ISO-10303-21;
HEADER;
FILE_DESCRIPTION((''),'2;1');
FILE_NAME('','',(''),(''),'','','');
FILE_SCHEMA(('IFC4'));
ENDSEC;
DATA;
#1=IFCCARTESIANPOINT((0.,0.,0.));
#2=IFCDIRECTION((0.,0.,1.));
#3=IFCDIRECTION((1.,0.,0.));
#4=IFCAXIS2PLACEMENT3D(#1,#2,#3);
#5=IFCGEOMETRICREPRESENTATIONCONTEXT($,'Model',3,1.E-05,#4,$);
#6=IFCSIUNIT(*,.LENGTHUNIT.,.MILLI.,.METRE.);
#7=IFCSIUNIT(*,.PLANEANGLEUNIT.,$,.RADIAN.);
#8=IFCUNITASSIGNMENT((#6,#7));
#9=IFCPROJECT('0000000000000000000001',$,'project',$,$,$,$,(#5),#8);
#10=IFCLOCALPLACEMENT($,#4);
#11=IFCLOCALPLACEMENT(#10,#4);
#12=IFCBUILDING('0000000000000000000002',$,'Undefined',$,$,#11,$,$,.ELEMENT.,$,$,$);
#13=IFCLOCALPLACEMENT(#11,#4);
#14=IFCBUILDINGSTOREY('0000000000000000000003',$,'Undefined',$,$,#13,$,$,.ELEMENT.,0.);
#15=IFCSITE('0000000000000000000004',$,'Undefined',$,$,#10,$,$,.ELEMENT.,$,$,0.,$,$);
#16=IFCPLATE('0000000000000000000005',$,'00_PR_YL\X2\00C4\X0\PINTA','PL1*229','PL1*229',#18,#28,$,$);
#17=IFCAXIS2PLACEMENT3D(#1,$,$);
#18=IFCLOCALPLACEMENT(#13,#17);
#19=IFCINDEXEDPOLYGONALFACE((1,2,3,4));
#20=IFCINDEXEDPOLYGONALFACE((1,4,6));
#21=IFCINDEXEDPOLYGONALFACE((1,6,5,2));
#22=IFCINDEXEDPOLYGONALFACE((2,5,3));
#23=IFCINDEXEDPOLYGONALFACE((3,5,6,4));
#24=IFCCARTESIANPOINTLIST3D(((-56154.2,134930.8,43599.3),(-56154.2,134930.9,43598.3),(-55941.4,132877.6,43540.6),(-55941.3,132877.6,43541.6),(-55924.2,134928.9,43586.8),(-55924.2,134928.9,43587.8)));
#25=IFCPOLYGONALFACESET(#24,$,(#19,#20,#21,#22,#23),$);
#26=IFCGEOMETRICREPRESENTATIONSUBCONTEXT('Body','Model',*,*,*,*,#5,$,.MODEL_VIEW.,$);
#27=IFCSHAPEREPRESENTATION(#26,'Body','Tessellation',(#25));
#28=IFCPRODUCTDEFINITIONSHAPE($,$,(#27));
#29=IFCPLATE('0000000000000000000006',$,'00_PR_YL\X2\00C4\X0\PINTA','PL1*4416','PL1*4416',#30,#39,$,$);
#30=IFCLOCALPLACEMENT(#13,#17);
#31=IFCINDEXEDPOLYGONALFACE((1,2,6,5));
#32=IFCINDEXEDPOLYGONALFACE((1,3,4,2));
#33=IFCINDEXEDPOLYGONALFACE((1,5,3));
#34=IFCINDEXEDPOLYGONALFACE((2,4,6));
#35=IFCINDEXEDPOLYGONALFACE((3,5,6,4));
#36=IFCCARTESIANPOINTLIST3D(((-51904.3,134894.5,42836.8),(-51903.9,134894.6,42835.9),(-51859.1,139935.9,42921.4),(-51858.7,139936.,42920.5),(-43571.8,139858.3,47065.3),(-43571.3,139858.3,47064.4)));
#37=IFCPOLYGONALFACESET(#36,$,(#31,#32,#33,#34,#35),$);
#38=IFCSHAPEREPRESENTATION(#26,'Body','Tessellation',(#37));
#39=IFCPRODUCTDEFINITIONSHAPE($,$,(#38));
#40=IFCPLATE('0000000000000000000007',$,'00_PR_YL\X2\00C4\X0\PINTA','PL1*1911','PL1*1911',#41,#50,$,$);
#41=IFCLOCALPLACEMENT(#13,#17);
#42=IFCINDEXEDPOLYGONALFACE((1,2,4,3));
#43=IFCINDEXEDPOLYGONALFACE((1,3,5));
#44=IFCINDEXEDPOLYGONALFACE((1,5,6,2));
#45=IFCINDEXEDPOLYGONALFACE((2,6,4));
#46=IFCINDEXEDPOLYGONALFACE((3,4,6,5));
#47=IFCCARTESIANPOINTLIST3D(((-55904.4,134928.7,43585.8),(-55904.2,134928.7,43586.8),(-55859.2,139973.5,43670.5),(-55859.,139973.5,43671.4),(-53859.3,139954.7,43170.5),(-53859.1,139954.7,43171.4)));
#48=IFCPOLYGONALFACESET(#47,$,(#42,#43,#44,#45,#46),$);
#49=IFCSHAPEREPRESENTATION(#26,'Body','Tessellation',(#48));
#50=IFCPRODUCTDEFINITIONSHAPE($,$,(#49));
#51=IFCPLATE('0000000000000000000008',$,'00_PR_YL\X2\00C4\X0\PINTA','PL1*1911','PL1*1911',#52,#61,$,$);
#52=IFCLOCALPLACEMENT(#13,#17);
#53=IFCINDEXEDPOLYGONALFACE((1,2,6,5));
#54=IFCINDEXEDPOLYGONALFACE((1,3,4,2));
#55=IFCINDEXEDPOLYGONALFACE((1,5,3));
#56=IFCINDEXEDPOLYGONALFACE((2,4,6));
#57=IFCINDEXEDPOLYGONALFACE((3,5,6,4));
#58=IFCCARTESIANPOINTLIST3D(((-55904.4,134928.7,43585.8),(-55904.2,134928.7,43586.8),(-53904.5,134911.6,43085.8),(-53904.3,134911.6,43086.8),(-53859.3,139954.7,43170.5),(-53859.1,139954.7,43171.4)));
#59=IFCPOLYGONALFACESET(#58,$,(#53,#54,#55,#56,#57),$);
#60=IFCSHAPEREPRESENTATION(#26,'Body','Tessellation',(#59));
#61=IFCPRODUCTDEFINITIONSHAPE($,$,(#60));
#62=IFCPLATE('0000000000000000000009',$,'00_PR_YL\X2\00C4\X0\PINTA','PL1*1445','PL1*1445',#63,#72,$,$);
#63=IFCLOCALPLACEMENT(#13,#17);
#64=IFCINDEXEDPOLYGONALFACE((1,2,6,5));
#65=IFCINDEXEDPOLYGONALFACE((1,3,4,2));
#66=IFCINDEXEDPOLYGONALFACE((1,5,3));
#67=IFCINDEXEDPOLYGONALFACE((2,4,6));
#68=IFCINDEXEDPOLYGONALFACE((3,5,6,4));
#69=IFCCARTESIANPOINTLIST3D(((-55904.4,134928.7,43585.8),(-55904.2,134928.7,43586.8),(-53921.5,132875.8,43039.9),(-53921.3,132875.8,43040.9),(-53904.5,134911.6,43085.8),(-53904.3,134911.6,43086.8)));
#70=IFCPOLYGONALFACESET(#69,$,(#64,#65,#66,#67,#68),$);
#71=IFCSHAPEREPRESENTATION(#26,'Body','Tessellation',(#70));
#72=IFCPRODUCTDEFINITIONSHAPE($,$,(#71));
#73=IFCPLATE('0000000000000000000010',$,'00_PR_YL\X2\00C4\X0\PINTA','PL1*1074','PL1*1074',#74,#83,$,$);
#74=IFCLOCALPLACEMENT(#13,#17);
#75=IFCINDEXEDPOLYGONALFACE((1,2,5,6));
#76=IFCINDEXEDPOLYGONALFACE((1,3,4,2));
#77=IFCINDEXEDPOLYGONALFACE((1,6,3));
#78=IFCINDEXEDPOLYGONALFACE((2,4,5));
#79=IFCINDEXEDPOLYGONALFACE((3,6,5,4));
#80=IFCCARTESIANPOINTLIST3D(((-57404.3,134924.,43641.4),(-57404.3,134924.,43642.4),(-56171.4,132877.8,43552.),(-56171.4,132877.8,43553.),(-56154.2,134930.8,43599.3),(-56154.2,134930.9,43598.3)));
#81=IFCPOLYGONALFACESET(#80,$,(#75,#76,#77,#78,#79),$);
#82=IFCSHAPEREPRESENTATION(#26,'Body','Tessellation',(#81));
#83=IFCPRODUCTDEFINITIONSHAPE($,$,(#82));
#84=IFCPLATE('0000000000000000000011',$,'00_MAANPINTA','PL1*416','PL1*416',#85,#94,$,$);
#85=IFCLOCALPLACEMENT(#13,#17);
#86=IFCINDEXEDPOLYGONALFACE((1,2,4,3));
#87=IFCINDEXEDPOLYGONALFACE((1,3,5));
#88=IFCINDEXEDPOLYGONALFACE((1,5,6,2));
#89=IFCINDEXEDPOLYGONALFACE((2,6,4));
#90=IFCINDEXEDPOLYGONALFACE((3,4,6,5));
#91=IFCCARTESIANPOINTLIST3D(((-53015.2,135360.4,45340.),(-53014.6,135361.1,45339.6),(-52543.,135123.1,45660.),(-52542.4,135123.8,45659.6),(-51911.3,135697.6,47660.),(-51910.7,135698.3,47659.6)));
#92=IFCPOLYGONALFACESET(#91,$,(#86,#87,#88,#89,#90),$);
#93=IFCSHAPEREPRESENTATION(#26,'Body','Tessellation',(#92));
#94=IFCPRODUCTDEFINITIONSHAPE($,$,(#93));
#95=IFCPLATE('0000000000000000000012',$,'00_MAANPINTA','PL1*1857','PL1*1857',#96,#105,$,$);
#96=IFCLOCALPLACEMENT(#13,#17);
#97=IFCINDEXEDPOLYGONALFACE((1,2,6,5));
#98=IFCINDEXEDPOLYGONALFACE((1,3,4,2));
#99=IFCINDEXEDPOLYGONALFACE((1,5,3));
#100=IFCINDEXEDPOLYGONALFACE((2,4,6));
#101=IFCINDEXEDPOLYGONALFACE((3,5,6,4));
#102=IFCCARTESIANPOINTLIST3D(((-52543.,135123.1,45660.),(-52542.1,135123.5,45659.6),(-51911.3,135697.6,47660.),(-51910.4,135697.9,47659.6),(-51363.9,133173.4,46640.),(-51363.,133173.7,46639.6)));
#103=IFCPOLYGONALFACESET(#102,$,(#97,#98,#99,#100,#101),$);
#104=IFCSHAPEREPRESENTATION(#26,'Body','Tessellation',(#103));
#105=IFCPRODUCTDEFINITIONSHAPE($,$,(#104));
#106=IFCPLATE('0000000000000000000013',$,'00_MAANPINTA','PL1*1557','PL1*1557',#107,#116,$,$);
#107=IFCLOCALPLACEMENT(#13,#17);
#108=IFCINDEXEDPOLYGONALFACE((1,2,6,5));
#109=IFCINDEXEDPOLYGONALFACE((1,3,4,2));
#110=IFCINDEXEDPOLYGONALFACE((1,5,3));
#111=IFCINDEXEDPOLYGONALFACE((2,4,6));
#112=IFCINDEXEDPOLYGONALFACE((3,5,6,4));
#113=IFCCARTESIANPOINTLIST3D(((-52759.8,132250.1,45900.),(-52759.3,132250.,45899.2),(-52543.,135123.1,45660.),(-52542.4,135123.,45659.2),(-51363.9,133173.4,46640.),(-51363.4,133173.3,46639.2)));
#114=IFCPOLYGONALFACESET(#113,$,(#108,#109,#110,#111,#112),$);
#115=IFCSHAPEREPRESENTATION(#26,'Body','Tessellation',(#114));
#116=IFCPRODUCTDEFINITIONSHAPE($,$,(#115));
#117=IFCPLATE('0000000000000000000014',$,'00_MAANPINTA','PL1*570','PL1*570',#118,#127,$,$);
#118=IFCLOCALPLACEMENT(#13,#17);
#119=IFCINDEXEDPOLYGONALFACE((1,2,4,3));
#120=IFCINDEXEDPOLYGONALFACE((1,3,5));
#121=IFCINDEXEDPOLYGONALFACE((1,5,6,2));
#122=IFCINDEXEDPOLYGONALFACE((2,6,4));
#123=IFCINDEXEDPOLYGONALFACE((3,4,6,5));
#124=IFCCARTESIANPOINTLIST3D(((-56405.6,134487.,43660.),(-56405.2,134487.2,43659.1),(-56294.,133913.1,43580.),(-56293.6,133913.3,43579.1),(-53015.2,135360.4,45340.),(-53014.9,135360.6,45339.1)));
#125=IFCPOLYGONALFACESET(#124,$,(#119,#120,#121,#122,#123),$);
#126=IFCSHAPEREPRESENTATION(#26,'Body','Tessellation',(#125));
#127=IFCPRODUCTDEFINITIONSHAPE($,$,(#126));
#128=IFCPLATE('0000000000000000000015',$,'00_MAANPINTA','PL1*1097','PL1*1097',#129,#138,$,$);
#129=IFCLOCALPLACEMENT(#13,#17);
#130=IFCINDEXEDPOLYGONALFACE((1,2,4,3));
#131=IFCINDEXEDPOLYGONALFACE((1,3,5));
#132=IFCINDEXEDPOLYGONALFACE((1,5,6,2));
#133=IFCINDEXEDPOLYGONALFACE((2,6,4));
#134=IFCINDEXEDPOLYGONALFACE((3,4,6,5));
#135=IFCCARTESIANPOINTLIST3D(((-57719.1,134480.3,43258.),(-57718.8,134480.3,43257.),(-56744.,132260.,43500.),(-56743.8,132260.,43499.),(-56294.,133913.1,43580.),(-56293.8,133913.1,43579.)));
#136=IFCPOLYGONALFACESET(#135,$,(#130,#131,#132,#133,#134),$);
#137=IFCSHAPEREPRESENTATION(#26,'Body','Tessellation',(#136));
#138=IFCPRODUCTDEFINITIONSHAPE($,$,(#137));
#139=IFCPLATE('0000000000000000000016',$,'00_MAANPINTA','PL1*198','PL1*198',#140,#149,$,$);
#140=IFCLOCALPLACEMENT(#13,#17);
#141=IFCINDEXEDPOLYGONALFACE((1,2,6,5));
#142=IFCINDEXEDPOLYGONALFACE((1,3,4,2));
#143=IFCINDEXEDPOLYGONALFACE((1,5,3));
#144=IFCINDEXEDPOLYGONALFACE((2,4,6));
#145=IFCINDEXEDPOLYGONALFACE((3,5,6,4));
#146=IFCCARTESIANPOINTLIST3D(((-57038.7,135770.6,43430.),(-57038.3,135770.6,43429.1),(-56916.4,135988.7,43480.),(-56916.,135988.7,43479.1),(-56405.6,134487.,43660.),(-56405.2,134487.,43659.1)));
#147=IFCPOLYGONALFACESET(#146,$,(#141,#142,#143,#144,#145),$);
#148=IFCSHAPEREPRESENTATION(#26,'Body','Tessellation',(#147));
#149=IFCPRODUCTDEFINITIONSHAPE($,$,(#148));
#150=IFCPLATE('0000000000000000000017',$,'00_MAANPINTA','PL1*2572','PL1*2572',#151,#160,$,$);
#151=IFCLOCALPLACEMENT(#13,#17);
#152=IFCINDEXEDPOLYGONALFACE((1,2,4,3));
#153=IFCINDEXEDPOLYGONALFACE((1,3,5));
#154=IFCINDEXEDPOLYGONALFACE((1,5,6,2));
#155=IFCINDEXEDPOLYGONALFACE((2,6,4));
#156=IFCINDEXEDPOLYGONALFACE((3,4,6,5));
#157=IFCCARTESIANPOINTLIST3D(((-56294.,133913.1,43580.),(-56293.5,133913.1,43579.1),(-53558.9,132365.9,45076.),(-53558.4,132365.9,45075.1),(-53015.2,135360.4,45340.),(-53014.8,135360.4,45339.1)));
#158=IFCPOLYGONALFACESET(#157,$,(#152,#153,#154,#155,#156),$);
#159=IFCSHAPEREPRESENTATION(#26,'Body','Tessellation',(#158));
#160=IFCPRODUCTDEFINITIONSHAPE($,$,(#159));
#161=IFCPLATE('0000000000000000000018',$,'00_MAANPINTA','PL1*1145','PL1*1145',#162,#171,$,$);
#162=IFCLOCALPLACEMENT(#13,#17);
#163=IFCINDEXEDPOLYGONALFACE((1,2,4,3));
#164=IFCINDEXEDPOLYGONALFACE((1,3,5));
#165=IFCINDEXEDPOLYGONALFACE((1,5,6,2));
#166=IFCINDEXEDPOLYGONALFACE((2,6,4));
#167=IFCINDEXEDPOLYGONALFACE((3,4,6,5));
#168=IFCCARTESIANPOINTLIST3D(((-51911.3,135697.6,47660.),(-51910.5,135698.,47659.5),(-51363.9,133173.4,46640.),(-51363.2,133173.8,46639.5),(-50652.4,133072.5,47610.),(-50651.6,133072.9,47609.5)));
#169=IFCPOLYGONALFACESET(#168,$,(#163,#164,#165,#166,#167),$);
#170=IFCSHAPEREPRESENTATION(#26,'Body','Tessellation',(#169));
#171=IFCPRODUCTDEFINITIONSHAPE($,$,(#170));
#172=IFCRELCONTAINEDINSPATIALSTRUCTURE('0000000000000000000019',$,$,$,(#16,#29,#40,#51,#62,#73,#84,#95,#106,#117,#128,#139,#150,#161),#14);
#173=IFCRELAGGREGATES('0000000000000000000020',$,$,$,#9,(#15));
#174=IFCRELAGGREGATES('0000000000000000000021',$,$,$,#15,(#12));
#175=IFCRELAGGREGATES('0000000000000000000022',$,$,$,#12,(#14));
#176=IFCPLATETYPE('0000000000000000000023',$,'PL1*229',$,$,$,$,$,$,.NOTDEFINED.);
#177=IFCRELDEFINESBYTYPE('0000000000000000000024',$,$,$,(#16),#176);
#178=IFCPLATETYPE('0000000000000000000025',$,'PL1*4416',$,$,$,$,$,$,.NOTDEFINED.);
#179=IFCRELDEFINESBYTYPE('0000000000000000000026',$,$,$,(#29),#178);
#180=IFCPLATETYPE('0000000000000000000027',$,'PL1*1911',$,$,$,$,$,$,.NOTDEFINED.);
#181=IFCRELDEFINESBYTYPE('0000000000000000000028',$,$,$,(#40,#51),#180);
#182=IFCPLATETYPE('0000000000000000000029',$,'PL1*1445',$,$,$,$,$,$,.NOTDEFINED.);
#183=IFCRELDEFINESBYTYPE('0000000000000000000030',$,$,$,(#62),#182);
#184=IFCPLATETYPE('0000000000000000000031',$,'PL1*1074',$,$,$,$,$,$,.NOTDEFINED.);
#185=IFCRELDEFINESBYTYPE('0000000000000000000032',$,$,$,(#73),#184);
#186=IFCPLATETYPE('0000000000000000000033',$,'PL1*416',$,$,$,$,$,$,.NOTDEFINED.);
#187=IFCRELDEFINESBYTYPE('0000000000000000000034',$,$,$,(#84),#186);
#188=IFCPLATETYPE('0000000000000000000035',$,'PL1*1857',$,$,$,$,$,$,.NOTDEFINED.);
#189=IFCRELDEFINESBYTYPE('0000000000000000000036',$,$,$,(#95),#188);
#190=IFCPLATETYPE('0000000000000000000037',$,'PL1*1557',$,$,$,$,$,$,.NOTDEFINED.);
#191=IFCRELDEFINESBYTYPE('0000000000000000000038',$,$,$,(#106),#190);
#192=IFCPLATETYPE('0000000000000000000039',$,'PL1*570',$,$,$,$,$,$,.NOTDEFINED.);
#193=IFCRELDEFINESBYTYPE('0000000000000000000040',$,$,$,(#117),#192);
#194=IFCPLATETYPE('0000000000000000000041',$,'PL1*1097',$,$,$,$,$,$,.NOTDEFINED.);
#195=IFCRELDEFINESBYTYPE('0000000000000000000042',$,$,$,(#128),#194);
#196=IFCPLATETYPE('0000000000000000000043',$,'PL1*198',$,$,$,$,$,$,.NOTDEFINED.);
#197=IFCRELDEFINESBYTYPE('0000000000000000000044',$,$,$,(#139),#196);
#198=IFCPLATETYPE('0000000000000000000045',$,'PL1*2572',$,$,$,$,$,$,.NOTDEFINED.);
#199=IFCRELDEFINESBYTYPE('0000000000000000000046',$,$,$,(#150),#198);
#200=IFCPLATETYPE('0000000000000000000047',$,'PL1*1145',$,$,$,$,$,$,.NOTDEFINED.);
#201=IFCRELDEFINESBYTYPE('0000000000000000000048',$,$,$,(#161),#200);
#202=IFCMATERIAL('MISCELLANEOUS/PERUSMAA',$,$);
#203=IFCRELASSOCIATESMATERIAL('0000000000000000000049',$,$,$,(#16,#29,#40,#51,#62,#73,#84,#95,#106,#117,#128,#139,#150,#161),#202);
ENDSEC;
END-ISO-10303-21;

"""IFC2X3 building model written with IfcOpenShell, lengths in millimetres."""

from ifc_helpers import new_model, si_unit, frame, origin_with_axes, place, context, subcontext, project, spatial, polyline, outline, extrude, material, type_object, element, save


model = new_model("IFC2X3")

# Units and contexts
model_context = context("Model", 3, precision=1e-05, world=origin_with_axes())
body_context = subcontext(model_context, "Body", "Model", "MODEL_VIEW")
ifc_project = project(units=[si_unit("LENGTHUNIT", "METRE", prefix="MILLI"), si_unit("PLANEANGLEUNIT", "RADIAN")], contexts=[model_context])

# Site, building, storey
site_placement = place(None, origin_with_axes())
site = spatial("IfcSite", under=ifc_project, at=site_placement, Name="Undefined", CompositionType="ELEMENT", RefElevation=0.0)
building_placement = place(site_placement, origin_with_axes())
building = spatial("IfcBuilding", under=site, at=building_placement, Name="Undefined", CompositionType="ELEMENT")
storey_placement = place(building_placement, origin_with_axes())
storey = spatial("IfcBuildingStorey", under=building, at=storey_placement, Name="Undefined", CompositionType="ELEMENT", Elevation=0.0)

# Plates
ifc_material = material(Name="MISCELLANEOUS/PERUSMAA")
plate_type_1 = type_object("IfcPlateType", Name="PL1*229", PredefinedType="NOTDEFINED")
plate_1_placement = place(storey_placement, frame((-55924.2, 134928.9, 43587.3), z_axis=(-0.049732, 0.022903, -0.9985), x_axis=(-0.008366, -0.999712, -0.022514)))
element("IfcPlate", 1, at=plate_1_placement, inside=storey, type_object=plate_type_1, material=ifc_material, Name="00_PR_YLÄPINTA", Description="PL1*229", ObjectType="PL1*229", context=body_context, shape_type="SweptSolid", body=[
    extrude(outline(polyline([(0.0, 0.0), (2051.9, 0.0), (-0.3, 230.3), (0.0, 0.0)])), frame((0.0, 0.0, -0.5), z_axis=(0.0, 0.0, 1.0), x_axis=(1.0, 0.0, 0.0)), (0.0, 0.0, 1.0), 1.0),
])
plate_type_2 = type_object("IfcPlateType", Name="PL1*4416", PredefinedType="NOTDEFINED")
plate_2_placement = place(storey_placement, frame((-51904.1, 134894.6, 42836.3), z_axis=(0.447285, 0.011013, -0.894324), x_axis=(0.00896, 0.999819, 0.016793)))
element("IfcPlate", 2, at=plate_2_placement, inside=storey, type_object=plate_type_2, material=ifc_material, Name="00_PR_YLÄPINTA", Description="PL1*4416", ObjectType="PL1*4416", context=body_context, shape_type="SweptSolid", body=[
    extrude(outline(polyline([(0.0, 0.0), (5042.3, 0.0), (5108.5, 9265.8), (0.0, 0.0)])), frame((0.0, 0.0, -0.5), z_axis=(0.0, 0.0, 1.0), x_axis=(1.0, 0.0, 0.0)), (0.0, 0.0, 1.0), 1.0),
])
plate_type_3 = type_object("IfcPlateType", Name="PL1*1911", PredefinedType="NOTDEFINED")
plate_3_placement = place(storey_placement, frame((-53859.2, 139954.7, 43171.0), z_axis=(-0.242341, 0.018453, -0.970016), x_axis=(-0.3758, -0.923553, 0.076318)))
element("IfcPlate", 3, at=plate_3_placement, inside=storey, type_object=plate_type_3, material=ifc_material, Name="00_PR_YLÄPINTA", Description="PL1*1911", ObjectType="PL1*1911", context=body_context, shape_type="SweptSolid", body=[
    extrude(outline(polyline([(0.0, 0.0), (5442.0, 0.0), (772.4, 1911.4), (0.0, 0.0)])), frame((0.0, 0.0, -0.5), z_axis=(0.0, 0.0, 1.0), x_axis=(1.0, 0.0, 0.0)), (0.0, 0.0, 1.0), 1.0),
])
plate_4_placement = place(storey_placement, frame((-53859.2, 139954.7, 43171.0), z_axis=(-0.242354, 0.018459, -0.970012), x_axis=(-0.00896, -0.999819, -0.016788)))
element("IfcPlate", 4, at=plate_4_placement, inside=storey, type_object=plate_type_3, material=ifc_material, Name="00_PR_YLÄPINTA", Description="PL1*1911", ObjectType="PL1*1911", context=body_context, shape_type="SweptSolid", body=[
    extrude(outline(polyline([(0.0, 0.0), (5044.0, 0.0), (5036.4, 2061.5), (0.0, 0.0)])), frame((0.0, 0.0, -0.5), z_axis=(0.0, 0.0, 1.0), x_axis=(1.0, 0.0, 0.0)), (0.0, 0.0, 1.0), 1.0),
])
plate_type_4 = type_object("IfcPlateType", Name="PL1*1445", PredefinedType="NOTDEFINED")
plate_5_placement = place(storey_placement, frame((-55904.3, 134928.7, 43586.3), z_axis=(-0.242283, 0.023878, -0.969912), x_axis=(0.970107, -0.008284, -0.242536)))
element("IfcPlate", 5, at=plate_5_placement, inside=storey, type_object=plate_type_4, material=ifc_material, Name="00_PR_YLÄPINTA", Description="PL1*1445", ObjectType="PL1*1445", context=body_context, shape_type="SweptSolid", body=[
    extrude(outline(polyline([(0.0, 0.0), (2061.6, 0.0), (2073.0, 2036.4), (0.0, 0.0)])), frame((0.0, 0.0, -0.5), z_axis=(0.0, 0.0, 1.0), x_axis=(1.0, 0.0, 0.0)), (0.0, 0.0, 1.0), 1.0),
])
plate_type_5 = type_object("IfcPlateType", Name="PL1*1074", PredefinedType="NOTDEFINED")
plate_6_placement = place(storey_placement, frame((-56154.2, 134930.8, 43598.8), z_axis=(-0.03464, 0.022791, -0.99914), x_axis=(-0.008365, -0.999712, -0.022514)))
element("IfcPlate", 6, at=plate_6_placement, inside=storey, type_object=plate_type_5, material=ifc_material, Name="00_PR_YLÄPINTA", Description="PL1*1074", ObjectType="PL1*1074", context=body_context, shape_type="SweptSolid", body=[
    extrude(outline(polyline([(0.0, 0.0), (2053.6, 0.0), (16.3, 1250.8), (0.0, 0.0)])), frame((0.0, 0.0, -0.5), z_axis=(0.0, 0.0, 1.0), x_axis=(1.0, 0.0, 0.0)), (0.0, 0.0, 1.0), 1.0),
])
plate_type_6 = type_object("IfcPlateType", Name="PL1*416", PredefinedType="NOTDEFINED")
plate_7_placement = place(storey_placement, frame((-51911.0, 135697.9, 47659.8), z_axis=(0.610773, 0.688694, -0.390714), x_axis=(-0.290468, -0.264166, -0.919698)))
element("IfcPlate", 7, at=plate_7_placement, inside=storey, type_object=plate_type_6, material=ifc_material, Name="00_MAANPINTA", Description="PL1*416", ObjectType="PL1*416", context=body_context, shape_type="SweptSolid", body=[
    extrude(outline(polyline([(0.0, 0.0), (2174.6, 0.0), (2543.4, 495.7), (0.0, 0.0)])), frame((0.0, 0.0, -0.5), z_axis=(0.0, 0.0, 1.0), x_axis=(1.0, 0.0, 0.0)), (0.0, 0.0, 1.0), 1.0),
])
plate_type_7 = type_object("IfcPlateType", Name="PL1*1857", PredefinedType="NOTDEFINED")
plate_8_placement = place(storey_placement, frame((-51363.5, 133173.6, 46639.8), z_axis=(0.86553, 0.337307, -0.370245), x_axis=(-0.475359, 0.786082, -0.395107)))
element("IfcPlate", 8, at=plate_8_placement, inside=storey, type_object=plate_type_7, material=ifc_material, Name="00_MAANPINTA", Description="PL1*1857", ObjectType="PL1*1857", context=body_context, shape_type="SweptSolid", body=[
    extrude(outline(polyline([(0.0, 0.0), (2480.3, 0.0), (1841.4, 2078.7), (0.0, 0.0)])), frame((0.0, 0.0, -0.5), z_axis=(0.0, 0.0, 1.0), x_axis=(1.0, 0.0, 0.0)), (0.0, 0.0, 1.0), 1.0),
])
plate_type_8 = type_object("IfcPlateType", Name="PL1*1557", PredefinedType="NOTDEFINED")
plate_9_placement = place(storey_placement, frame((-52542.7, 135123.1, 45659.6), z_axis=(0.521377, -0.110038, -0.846202), x_axis=(0.475359, -0.786082, 0.395107)))
element("IfcPlate", 9, at=plate_9_placement, inside=storey, type_object=plate_type_8, material=ifc_material, Name="00_MAANPINTA", Description="PL1*1557", ObjectType="PL1*1557", context=body_context, shape_type="SweptSolid", body=[
    extrude(outline(polyline([(0.0, 0.0), (2480.3, 0.0), (2250.2, 1815.4), (0.0, 0.0)])), frame((0.0, 0.0, -0.5), z_axis=(0.0, 0.0, 1.0), x_axis=(1.0, 0.0, 0.0)), (0.0, 0.0, 1.0), 1.0),
])
plate_type_9 = type_object("IfcPlateType", Name="PL1*570", PredefinedType="NOTDEFINED")
plate_10_placement = place(storey_placement, frame((-56293.8, 133913.2, 43579.6), z_axis=(0.392745, 0.201443, -0.897314), x_axis=(-0.189086, 0.972556, 0.135574)))
element("IfcPlate", 10, at=plate_10_placement, inside=storey, type_object=plate_type_9, material=ifc_material, Name="00_MAANPINTA", Description="PL1*570", ObjectType="PL1*570", context=body_context, shape_type="SweptSolid", body=[
    extrude(outline(polyline([(0.0, 0.0), (590.1, 0.0), (1026.3, 3858.7), (0.0, 0.0)])), frame((0.0, 0.0, -0.5), z_axis=(0.0, 0.0, 1.0), x_axis=(1.0, 0.0, 0.0)), (0.0, 0.0, 1.0), 1.0),
])
plate_type_10 = type_object("IfcPlateType", Name="PL1*1097", PredefinedType="NOTDEFINED")
plate_11_placement = place(storey_placement, frame((-56293.9, 133913.1, 43579.5), z_axis=(0.216009, -0.011553, -0.976323), x_axis=(-0.262369, -0.96384, -0.046643)))
element("IfcPlate", 11, at=plate_11_placement, inside=storey, type_object=plate_type_10, material=ifc_material, Name="00_MAANPINTA", Description="PL1*1097", ObjectType="PL1*1097", context=body_context, shape_type="SweptSolid", body=[
    extrude(outline(polyline([(0.0, 0.0), (1715.1, 0.0), (-157.8, 1559.3), (0.0, 0.0)])), frame((0.0, 0.0, -0.5), z_axis=(0.0, 0.0, 1.0), x_axis=(1.0, 0.0, 0.0)), (0.0, 0.0, 1.0), 1.0),
])
plate_type_11 = type_object("IfcPlateType", Name="PL1*198", PredefinedType="NOTDEFINED")
plate_12_placement = place(storey_placement, frame((-57038.5, 135770.6, 43429.5), z_axis=(0.361361, 0.011164, -0.932359), x_axis=(0.479582, 0.855301, 0.196116)))
element("IfcPlate", 12, at=plate_12_placement, inside=storey, type_object=plate_type_11, material=ifc_material, Name="00_MAANPINTA", Description="PL1*198", ObjectType="PL1*198", context=body_context, shape_type="SweptSolid", body=[
    extrude(outline(polyline([(0.0, 0.0), (255.0, 0.0), (-749.2, 1241.0), (0.0, 0.0)])), frame((0.0, 0.0, -0.5), z_axis=(0.0, 0.0, 1.0), x_axis=(1.0, 0.0, 0.0)), (0.0, 0.0, 1.0), 1.0),
])
plate_type_12 = type_object("IfcPlateType", Name="PL1*2572", PredefinedType="NOTDEFINED")
plate_13_placement = place(storey_placement, frame((-53015.0, 135360.4, 45339.6), z_axis=(0.475977, -0.008876, -0.879413), x_axis=(-0.177947, -0.980238, -0.086419)))
element("IfcPlate", 13, at=plate_13_placement, inside=storey, type_object=plate_type_12, material=ifc_material, Name="00_MAANPINTA", Description="PL1*2572", ObjectType="PL1*2572", context=body_context, shape_type="SweptSolid", body=[
    extrude(outline(polyline([(0.0, 0.0), (3054.9, 0.0), (2154.3, 3361.8), (0.0, 0.0)])), frame((0.0, 0.0, -0.5), z_axis=(0.0, 0.0, 1.0), x_axis=(1.0, 0.0, 0.0)), (0.0, 0.0, 1.0), 1.0),
])
plate_type_13 = type_object("IfcPlateType", Name="PL1*1145", PredefinedType="NOTDEFINED")
plate_14_placement = place(storey_placement, frame((-51910.9, 135697.8, 47659.7), z_axis=(0.765121, 0.376881, -0.522064), x_axis=(0.43236, -0.901538, -0.017171)))
element("IfcPlate", 14, at=plate_14_placement, inside=storey, type_object=plate_type_13, material=ifc_material, Name="00_MAANPINTA", Description="PL1*1145", ObjectType="PL1*1145", context=body_context, shape_type="SweptSolid", body=[
    extrude(outline(polyline([(0.0, 0.0), (2911.8, 0.0), (2529.9, 1145.2), (0.0, 0.0)])), frame((0.0, 0.0, -0.5), z_axis=(0.0, 0.0, 1.0), x_axis=(1.0, 0.0, 0.0)), (0.0, 0.0, 1.0), 1.0),
])

save(model, "model.ifc")
